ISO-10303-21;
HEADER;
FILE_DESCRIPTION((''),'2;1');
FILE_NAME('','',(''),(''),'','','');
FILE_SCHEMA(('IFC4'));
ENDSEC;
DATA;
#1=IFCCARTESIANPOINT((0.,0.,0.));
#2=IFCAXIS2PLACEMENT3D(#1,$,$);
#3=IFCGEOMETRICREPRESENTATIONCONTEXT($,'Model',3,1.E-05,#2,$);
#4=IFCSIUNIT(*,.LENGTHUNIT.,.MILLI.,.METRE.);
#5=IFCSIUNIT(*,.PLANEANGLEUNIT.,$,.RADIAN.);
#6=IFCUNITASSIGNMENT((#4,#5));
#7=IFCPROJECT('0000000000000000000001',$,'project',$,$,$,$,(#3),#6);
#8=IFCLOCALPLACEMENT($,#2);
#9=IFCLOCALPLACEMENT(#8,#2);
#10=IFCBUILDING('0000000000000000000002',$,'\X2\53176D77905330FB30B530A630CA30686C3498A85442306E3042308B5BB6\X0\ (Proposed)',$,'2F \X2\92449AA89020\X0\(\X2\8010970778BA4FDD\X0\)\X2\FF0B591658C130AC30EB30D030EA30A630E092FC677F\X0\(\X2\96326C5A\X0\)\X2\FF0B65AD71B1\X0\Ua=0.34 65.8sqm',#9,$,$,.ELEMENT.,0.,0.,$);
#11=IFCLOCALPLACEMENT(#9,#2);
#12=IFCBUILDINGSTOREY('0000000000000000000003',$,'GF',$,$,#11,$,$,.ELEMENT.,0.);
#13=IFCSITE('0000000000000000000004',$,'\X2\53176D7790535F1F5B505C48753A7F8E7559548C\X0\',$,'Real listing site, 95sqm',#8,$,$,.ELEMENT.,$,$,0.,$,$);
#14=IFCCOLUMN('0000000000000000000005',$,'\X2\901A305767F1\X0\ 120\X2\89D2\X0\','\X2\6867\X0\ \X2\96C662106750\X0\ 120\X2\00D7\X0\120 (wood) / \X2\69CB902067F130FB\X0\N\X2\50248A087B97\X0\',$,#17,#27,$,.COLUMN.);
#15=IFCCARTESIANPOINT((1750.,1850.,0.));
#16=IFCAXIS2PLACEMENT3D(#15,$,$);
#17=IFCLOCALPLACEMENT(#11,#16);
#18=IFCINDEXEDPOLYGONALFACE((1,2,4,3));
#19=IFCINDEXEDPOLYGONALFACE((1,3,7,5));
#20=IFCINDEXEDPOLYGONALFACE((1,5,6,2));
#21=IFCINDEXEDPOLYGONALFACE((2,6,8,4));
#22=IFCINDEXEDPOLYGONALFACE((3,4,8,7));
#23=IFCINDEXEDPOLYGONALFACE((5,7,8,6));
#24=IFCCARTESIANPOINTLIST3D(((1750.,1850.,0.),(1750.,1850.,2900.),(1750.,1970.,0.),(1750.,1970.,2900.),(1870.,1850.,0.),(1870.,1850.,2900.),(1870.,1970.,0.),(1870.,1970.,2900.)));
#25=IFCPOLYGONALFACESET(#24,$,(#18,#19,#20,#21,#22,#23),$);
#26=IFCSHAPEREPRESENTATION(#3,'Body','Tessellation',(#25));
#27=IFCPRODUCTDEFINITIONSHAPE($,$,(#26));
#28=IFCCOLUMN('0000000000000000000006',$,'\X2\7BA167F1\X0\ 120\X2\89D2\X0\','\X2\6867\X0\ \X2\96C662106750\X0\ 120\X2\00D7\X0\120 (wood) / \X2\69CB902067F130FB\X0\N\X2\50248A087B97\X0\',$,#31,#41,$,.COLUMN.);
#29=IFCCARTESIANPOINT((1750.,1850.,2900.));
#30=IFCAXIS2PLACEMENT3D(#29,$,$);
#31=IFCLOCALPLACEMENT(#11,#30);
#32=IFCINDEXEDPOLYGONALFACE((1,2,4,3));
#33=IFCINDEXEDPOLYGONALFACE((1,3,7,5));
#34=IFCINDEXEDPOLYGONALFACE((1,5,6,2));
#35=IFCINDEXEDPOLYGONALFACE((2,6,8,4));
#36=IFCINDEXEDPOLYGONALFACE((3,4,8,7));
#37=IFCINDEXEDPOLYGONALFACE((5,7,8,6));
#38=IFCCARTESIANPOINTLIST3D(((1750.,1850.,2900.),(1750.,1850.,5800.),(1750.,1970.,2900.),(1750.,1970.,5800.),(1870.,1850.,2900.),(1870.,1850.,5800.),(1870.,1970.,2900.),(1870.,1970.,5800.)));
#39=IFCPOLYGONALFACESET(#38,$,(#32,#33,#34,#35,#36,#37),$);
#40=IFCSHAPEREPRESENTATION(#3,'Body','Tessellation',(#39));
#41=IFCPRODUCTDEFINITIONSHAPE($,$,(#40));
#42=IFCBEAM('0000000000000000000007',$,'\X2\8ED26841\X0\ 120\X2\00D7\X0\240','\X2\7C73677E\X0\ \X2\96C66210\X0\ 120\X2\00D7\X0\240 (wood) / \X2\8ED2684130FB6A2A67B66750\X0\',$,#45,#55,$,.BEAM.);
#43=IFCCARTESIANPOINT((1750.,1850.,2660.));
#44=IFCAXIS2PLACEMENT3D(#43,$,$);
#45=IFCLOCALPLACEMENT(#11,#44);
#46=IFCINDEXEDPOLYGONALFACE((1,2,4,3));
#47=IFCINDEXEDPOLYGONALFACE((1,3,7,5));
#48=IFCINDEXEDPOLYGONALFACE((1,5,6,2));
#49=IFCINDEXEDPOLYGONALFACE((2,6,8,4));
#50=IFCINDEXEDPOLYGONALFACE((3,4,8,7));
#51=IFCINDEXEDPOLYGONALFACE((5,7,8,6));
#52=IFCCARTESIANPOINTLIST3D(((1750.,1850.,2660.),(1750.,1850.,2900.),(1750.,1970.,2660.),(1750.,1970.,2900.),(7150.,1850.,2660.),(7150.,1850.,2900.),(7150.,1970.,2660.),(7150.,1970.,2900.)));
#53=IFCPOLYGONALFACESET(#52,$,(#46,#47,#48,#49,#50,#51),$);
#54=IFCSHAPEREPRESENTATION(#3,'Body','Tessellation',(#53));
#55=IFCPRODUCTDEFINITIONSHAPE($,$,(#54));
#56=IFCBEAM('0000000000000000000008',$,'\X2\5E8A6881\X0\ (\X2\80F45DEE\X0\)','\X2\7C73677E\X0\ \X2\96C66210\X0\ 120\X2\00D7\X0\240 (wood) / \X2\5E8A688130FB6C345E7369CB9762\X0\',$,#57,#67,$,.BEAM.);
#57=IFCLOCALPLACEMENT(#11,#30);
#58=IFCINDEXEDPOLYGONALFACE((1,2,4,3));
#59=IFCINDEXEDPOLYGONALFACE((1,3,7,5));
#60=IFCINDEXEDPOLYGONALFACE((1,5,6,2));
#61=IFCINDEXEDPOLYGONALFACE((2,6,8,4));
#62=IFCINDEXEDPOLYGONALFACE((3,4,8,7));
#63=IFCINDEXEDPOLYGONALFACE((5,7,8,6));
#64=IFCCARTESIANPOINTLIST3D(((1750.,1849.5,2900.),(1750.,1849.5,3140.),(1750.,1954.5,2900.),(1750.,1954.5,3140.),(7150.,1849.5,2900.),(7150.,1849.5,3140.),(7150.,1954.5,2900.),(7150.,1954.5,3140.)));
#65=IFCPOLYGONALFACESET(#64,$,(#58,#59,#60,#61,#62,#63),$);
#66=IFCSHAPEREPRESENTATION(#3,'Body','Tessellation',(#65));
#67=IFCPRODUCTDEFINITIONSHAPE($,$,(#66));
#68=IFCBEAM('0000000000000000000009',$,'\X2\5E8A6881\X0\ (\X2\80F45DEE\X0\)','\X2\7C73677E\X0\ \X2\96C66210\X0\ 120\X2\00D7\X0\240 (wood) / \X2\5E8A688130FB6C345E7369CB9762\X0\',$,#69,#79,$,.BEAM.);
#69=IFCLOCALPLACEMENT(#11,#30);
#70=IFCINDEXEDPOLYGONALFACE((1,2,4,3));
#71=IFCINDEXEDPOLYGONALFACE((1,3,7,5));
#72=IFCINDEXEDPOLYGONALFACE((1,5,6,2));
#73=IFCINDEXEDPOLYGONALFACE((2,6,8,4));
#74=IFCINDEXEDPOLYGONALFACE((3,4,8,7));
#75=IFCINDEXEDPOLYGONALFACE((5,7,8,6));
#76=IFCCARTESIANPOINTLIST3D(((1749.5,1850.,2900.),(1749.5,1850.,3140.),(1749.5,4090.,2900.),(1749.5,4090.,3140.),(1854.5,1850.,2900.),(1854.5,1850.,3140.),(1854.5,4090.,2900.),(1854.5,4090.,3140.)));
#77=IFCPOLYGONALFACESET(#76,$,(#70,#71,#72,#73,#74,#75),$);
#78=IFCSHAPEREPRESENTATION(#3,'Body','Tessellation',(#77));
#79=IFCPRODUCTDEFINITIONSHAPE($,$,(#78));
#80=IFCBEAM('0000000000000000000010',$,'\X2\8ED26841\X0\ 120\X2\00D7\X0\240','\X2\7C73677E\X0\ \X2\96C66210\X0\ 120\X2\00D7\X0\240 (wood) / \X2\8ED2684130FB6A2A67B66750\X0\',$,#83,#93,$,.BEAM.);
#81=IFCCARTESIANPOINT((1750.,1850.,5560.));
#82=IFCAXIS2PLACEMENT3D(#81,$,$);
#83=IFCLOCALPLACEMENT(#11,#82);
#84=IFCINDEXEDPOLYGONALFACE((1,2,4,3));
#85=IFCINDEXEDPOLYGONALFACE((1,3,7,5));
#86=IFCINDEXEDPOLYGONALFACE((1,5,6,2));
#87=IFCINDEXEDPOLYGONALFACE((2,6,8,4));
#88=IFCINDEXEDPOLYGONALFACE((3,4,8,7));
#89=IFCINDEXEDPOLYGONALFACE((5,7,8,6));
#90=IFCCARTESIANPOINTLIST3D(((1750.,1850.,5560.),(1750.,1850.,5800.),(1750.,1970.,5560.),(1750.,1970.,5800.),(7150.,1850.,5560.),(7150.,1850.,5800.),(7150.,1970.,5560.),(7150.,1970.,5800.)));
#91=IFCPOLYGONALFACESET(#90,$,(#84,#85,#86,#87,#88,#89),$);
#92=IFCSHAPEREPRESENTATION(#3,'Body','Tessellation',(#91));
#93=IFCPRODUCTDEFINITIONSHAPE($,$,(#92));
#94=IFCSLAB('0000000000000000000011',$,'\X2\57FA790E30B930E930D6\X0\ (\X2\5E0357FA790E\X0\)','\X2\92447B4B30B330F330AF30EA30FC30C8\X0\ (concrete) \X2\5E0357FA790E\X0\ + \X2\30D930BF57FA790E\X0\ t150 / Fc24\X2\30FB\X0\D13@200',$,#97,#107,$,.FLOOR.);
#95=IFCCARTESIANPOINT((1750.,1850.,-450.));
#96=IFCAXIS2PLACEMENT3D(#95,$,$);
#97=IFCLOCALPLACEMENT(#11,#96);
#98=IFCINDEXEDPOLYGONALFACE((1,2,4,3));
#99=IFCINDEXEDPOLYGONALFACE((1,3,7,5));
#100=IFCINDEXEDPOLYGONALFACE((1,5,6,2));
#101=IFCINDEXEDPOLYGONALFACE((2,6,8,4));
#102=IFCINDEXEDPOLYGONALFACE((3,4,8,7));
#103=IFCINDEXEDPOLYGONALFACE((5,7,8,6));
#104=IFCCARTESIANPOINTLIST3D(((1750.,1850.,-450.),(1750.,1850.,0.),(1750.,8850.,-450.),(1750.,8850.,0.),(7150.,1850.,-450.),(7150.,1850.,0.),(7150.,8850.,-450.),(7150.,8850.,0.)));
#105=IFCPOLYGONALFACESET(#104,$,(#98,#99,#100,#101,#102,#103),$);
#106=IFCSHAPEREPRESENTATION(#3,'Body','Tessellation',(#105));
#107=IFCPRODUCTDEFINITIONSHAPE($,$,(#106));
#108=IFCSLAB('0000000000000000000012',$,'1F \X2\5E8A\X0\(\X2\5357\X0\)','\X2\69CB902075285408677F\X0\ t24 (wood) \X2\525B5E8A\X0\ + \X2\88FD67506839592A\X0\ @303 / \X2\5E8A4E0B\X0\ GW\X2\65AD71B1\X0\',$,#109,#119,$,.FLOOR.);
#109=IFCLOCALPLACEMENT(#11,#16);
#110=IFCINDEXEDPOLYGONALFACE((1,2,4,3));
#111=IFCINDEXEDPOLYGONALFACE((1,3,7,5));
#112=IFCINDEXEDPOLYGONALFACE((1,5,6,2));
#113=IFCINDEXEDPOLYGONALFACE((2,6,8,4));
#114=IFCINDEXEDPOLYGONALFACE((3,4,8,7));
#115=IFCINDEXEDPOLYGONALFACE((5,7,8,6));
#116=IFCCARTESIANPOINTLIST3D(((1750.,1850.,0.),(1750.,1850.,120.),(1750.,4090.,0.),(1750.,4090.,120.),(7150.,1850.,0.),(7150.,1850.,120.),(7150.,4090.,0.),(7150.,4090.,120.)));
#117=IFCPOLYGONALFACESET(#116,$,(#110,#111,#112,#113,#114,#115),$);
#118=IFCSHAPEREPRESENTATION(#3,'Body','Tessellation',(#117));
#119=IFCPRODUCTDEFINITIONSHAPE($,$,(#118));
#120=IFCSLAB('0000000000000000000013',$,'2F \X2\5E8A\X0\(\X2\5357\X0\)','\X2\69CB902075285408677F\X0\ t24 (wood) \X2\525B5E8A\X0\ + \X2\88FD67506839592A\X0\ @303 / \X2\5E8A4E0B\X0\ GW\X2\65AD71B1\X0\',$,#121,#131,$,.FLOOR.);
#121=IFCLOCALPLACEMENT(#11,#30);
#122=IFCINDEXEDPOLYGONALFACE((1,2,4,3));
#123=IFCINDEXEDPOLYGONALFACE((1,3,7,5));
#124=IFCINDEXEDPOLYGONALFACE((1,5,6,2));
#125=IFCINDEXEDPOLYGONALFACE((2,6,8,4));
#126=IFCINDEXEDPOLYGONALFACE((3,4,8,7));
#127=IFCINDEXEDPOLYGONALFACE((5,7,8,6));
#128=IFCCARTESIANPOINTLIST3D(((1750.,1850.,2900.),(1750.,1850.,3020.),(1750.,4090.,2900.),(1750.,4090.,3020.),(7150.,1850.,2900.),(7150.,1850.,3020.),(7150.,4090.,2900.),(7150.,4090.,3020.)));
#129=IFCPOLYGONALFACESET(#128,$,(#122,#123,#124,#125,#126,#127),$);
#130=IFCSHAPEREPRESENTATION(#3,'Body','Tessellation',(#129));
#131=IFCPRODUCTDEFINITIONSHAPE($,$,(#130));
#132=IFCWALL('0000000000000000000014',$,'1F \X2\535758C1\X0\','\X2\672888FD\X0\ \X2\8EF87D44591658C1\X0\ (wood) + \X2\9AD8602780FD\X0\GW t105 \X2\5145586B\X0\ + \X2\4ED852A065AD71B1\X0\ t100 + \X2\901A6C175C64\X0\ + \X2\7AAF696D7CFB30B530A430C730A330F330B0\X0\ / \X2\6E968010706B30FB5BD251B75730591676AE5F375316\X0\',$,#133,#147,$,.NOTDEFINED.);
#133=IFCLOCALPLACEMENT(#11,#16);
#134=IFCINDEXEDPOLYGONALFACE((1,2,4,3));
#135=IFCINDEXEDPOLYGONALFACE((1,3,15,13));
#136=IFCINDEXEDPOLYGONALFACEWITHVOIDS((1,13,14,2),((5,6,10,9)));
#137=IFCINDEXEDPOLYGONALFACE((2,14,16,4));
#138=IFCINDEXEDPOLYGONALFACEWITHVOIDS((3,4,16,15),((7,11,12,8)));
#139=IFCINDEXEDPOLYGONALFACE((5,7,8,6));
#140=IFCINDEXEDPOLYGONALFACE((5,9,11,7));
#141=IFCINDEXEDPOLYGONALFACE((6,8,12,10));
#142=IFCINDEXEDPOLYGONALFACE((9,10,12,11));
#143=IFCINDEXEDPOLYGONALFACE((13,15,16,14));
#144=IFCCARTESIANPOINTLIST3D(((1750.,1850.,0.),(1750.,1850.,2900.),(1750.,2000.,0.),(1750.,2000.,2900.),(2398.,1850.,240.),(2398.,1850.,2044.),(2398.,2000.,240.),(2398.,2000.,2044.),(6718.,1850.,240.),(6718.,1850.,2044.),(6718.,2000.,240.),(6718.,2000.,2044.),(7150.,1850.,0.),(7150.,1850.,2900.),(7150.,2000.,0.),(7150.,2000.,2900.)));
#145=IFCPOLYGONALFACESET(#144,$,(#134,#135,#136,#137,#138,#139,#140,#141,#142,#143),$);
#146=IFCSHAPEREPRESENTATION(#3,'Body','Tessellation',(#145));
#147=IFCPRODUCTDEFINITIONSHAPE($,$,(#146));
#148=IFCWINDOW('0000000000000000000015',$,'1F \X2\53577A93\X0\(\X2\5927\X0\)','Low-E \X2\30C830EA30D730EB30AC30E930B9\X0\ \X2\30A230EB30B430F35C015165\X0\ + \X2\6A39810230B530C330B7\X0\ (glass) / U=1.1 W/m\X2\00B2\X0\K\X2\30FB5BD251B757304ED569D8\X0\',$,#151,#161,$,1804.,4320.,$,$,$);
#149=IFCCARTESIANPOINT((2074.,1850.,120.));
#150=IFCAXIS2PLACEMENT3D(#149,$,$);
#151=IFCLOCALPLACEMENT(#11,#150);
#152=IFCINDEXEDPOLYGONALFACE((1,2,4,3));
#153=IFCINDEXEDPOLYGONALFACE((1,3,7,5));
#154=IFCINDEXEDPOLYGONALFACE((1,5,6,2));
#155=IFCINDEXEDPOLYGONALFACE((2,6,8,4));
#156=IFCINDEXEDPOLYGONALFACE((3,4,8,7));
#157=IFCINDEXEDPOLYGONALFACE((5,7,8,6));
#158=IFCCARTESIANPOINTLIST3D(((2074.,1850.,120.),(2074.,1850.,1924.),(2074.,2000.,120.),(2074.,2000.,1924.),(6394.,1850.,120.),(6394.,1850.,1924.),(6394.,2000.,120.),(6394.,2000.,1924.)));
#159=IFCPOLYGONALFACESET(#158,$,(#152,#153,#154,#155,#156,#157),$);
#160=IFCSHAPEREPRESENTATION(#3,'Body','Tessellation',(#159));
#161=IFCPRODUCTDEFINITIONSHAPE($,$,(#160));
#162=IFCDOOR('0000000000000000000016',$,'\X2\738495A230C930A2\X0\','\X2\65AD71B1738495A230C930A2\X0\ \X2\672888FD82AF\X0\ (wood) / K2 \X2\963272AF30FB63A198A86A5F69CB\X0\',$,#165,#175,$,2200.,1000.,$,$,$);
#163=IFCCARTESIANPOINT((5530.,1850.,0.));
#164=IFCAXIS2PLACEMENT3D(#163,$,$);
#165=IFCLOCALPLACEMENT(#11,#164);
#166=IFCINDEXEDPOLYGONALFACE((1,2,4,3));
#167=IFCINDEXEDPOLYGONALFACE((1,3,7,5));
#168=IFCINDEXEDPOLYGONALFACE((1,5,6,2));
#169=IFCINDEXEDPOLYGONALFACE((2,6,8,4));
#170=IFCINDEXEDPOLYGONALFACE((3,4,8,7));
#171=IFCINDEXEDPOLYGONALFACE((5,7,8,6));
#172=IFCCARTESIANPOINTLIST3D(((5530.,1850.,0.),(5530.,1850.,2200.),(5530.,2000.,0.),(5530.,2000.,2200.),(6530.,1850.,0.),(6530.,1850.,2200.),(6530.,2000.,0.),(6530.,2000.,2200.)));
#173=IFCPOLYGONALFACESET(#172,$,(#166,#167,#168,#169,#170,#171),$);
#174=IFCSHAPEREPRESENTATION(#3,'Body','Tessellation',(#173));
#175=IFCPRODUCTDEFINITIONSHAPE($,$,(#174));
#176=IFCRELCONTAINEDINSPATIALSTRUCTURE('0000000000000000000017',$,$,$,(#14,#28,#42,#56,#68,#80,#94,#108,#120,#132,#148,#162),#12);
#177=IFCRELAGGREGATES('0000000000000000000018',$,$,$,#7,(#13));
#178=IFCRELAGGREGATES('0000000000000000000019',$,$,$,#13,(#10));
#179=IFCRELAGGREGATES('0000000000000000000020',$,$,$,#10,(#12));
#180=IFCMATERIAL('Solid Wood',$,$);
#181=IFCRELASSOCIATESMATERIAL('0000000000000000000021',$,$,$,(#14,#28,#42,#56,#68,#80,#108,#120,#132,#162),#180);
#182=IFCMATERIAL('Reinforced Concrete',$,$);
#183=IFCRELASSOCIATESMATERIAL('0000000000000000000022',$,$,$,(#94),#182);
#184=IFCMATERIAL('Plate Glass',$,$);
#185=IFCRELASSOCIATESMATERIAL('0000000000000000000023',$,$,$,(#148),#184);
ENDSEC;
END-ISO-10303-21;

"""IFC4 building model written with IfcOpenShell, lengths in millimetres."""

from ifc_helpers import new_model, si_unit, frame, frame_2d, origin, place, context, project, spatial, rectangle, extrude, material, element, fill, save


model = new_model("IFC4")

# Units and contexts
model_context = context("Model", 3, precision=1e-05, world=origin())
ifc_project = project(units=[si_unit("LENGTHUNIT", "METRE", prefix="MILLI"), si_unit("PLANEANGLEUNIT", "RADIAN")], contexts=[model_context])

# Site, building, storey
site_placement = place(None, origin())
site = spatial("IfcSite", under=ifc_project, at=site_placement, Name="北海道弟子屈町美留和", ObjectType="Real listing site, 95sqm", CompositionType="ELEMENT", RefElevation=0.0)
building_placement = place(site_placement, origin())
building = spatial("IfcBuilding", under=site, at=building_placement, Name="北海道・サウナと水風呂のある家 (Proposed)", ObjectType="2F 鉄骨造(耐震確保)＋外壁ガルバリウム鋼板(防汚)＋断熱Ua=0.34 65.8sqm", CompositionType="ELEMENT", ElevationOfRefHeight=0.0, ElevationOfTerrain=0.0)
storey_placement = place(building_placement, origin())
storey = spatial("IfcBuildingStorey", under=building, at=storey_placement, Name="GF", CompositionType="ELEMENT", Elevation=0.0)

# Columns
ifc_material_1 = material(Name="Solid Wood")
column_1_placement = place(storey_placement, frame((1750.0, 1850.0, 0.0)))
element("IfcColumn", 1, at=column_1_placement, inside=storey, material=ifc_material_1, Name="通し柱 120角", Description="桧 集成材 120×120 (wood) / 構造柱・N値計算", PredefinedType="COLUMN", context=model_context, shape_type="SweptSolid", body=[
    extrude(rectangle(XDim=120.0, YDim=120.0, at=frame_2d((60.0, 60.0))), frame((1750.0, 1850.0, 0.0)), (0.0, 0.0, 1.0), 2900.0),
])
column_2_placement = place(storey_placement, frame((1750.0, 1850.0, 2900.0)))
element("IfcColumn", 2, at=column_2_placement, inside=storey, material=ifc_material_1, Name="管柱 120角", Description="桧 集成材 120×120 (wood) / 構造柱・N値計算", PredefinedType="COLUMN", context=model_context, shape_type="SweptSolid", body=[
    extrude(rectangle(XDim=120.0, YDim=120.0, at=frame_2d((60.0, 60.0))), frame((1750.0, 1850.0, 2900.0)), (0.0, 0.0, 1.0), 2900.0),
])

# Beams
beam_1_placement = place(storey_placement, frame((1750.0, 1850.0, 2660.0)))
element("IfcBeam", 3, at=beam_1_placement, inside=storey, material=ifc_material_1, Name="軒桁 120×240", Description="米松 集成 120×240 (wood) / 軒桁・横架材", PredefinedType="BEAM", context=model_context, shape_type="SweptSolid", body=[
    extrude(rectangle(XDim=5400.0, YDim=120.0, at=frame_2d((2700.0, 60.0))), frame((1750.0, 1850.0, 2660.0)), (0.0, 0.0, 1.0), 240.0),
])
beam_2_placement = place(storey_placement, frame((1750.0, 1850.0, 2900.0)))
element("IfcBeam", 4, at=beam_2_placement, inside=storey, material=ifc_material_1, Name="床梁 (胴差)", Description="米松 集成 120×240 (wood) / 床梁・水平構面", PredefinedType="BEAM", context=model_context, shape_type="SweptSolid", body=[
    extrude(rectangle(XDim=5400.0, YDim=105.0, at=frame_2d((2700.0, 52.0))), frame((1750.0, 1850.0, 2900.0)), (0.0, 0.0, 1.0), 240.0),
])
beam_3_placement = place(storey_placement, frame((1750.0, 1850.0, 2900.0)))
element("IfcBeam", 5, at=beam_3_placement, inside=storey, material=ifc_material_1, Name="床梁 (胴差)", Description="米松 集成 120×240 (wood) / 床梁・水平構面", PredefinedType="BEAM", context=model_context, shape_type="SweptSolid", body=[
    extrude(rectangle(XDim=105.0, YDim=2240.0, at=frame_2d((52.0, 1120.0))), frame((1750.0, 1850.0, 2900.0)), (0.0, 0.0, 1.0), 240.0),
])
beam_4_placement = place(storey_placement, frame((1750.0, 1850.0, 5560.0)))
element("IfcBeam", 6, at=beam_4_placement, inside=storey, material=ifc_material_1, Name="軒桁 120×240", Description="米松 集成 120×240 (wood) / 軒桁・横架材", PredefinedType="BEAM", context=model_context, shape_type="SweptSolid", body=[
    extrude(rectangle(XDim=5400.0, YDim=120.0, at=frame_2d((2700.0, 60.0))), frame((1750.0, 1850.0, 5560.0)), (0.0, 0.0, 1.0), 240.0),
])

# Slabs
ifc_material_2 = material(Name="Reinforced Concrete")
slab_1_placement = place(storey_placement, frame((1750.0, 1850.0, -450.0)))
element("IfcSlab", 7, at=slab_1_placement, inside=storey, material=ifc_material_2, Name="基礎スラブ (布基礎)", Description="鉄筋コンクリート (concrete) 布基礎 + ベタ基礎 t150 / Fc24・D13@200", PredefinedType="FLOOR", context=model_context, shape_type="SweptSolid", body=[
    extrude(rectangle(XDim=5400.0, YDim=7000.0, at=frame_2d((2700.0, 3500.0))), frame((1750.0, 1850.0, -450.0)), (0.0, 0.0, 1.0), 450.0),
])
slab_2_placement = place(storey_placement, frame((1750.0, 1850.0, 0.0)))
element("IfcSlab", 8, at=slab_2_placement, inside=storey, material=ifc_material_1, Name="1F 床(南)", Description="構造用合板 t24 (wood) 剛床 + 製材根太 @303 / 床下 GW断熱", PredefinedType="FLOOR", context=model_context, shape_type="SweptSolid", body=[
    extrude(rectangle(XDim=5400.0, YDim=2240.0, at=frame_2d((2700.0, 1120.0))), frame((1750.0, 1850.0, 0.0)), (0.0, 0.0, 1.0), 120.0),
])
slab_3_placement = place(storey_placement, frame((1750.0, 1850.0, 2900.0)))
element("IfcSlab", 9, at=slab_3_placement, inside=storey, material=ifc_material_1, Name="2F 床(南)", Description="構造用合板 t24 (wood) 剛床 + 製材根太 @303 / 床下 GW断熱", PredefinedType="FLOOR", context=model_context, shape_type="SweptSolid", body=[
    extrude(rectangle(XDim=5400.0, YDim=2240.0, at=frame_2d((2700.0, 1120.0))), frame((1750.0, 1850.0, 2900.0)), (0.0, 0.0, 1.0), 120.0),
])

# Wall, openings, window, door
wall_1_placement = place(storey_placement, frame((1750.0, 1850.0, 0.0)))
wall_1 = element("IfcWall", 10, at=wall_1_placement, inside=storey, material=ifc_material_1, Name="1F 南壁", Description="木製 軸組外壁 (wood) + 高性能GW t105 充填 + 付加断熱 t100 + 通気層 + 窯業系サイディング / 準耐火・寒冷地外皮強化", PredefinedType="NOTDEFINED", context=model_context, shape_type="SweptSolid", body=[
    extrude(rectangle(XDim=5400.0, YDim=150.0, at=frame_2d((2700.0, 75.0))), frame((1750.0, 1850.0, 0.0)), (0.0, 0.0, 1.0), 2900.0),
])
opening_1_placement = place(storey_placement, frame((2074.0, 1850.0, 120.0)))
opening_1 = element("IfcOpeningElement", 11, at=opening_1_placement, cuts=wall_1, PredefinedType="NOTDEFINED", context=model_context, shape_type="SweptSolid", body=[
    extrude(rectangle(XDim=4320.0, YDim=150.0, at=frame_2d((2160.0, 75.0))), frame((2074.0, 1850.0, 120.0)), (0.0, 0.0, 1.0), 1804.0),
])
opening_2_placement = place(storey_placement, frame((5530.0, 1850.0, 0.0)))
opening_2 = element("IfcOpeningElement", 12, at=opening_2_placement, cuts=wall_1, PredefinedType="NOTDEFINED", context=model_context, shape_type="SweptSolid", body=[
    extrude(rectangle(XDim=1000.0, YDim=150.0, at=frame_2d((500.0, 75.0))), frame((5530.0, 1850.0, 0.0)), (0.0, 0.0, 1.0), 2200.0),
])
ifc_material_3 = material(Name="Plate Glass")
window_1_placement = place(storey_placement, frame((2074.0, 1850.0, 120.0)))
window_1 = element("IfcWindow", 13, at=window_1_placement, inside=storey, material=ifc_material_3, Name="1F 南窓(大)", Description="Low-E トリプルガラス アルゴン封入 + 樹脂サッシ (glass) / U=1.1 W/m²K・寒冷地仕様", OverallHeight=1804.0, OverallWidth=4320.0, context=model_context, shape_type="SweptSolid", body=[
    extrude(rectangle(XDim=4320.0, YDim=150.0, at=frame_2d((2160.0, 75.0))), frame((2074.0, 1850.0, 120.0)), (0.0, 0.0, 1.0), 1804.0),
])
fill(opening_1, window_1)
door_placement = place(storey_placement, frame((5530.0, 1850.0, 0.0)))
door = element("IfcDoor", 14, at=door_placement, inside=storey, material=ifc_material_1, Name="玄関ドア", Description="断熱玄関ドア 木製芯 (wood) / K2 防犯・採風機構", OverallHeight=2200.0, OverallWidth=1000.0, context=model_context, shape_type="SweptSolid", body=[
    extrude(rectangle(XDim=1000.0, YDim=150.0, at=frame_2d((500.0, 75.0))), frame((5530.0, 1850.0, 0.0)), (0.0, 0.0, 1.0), 2200.0),
])
fill(opening_2, door)

save(model, "model.ifc")
